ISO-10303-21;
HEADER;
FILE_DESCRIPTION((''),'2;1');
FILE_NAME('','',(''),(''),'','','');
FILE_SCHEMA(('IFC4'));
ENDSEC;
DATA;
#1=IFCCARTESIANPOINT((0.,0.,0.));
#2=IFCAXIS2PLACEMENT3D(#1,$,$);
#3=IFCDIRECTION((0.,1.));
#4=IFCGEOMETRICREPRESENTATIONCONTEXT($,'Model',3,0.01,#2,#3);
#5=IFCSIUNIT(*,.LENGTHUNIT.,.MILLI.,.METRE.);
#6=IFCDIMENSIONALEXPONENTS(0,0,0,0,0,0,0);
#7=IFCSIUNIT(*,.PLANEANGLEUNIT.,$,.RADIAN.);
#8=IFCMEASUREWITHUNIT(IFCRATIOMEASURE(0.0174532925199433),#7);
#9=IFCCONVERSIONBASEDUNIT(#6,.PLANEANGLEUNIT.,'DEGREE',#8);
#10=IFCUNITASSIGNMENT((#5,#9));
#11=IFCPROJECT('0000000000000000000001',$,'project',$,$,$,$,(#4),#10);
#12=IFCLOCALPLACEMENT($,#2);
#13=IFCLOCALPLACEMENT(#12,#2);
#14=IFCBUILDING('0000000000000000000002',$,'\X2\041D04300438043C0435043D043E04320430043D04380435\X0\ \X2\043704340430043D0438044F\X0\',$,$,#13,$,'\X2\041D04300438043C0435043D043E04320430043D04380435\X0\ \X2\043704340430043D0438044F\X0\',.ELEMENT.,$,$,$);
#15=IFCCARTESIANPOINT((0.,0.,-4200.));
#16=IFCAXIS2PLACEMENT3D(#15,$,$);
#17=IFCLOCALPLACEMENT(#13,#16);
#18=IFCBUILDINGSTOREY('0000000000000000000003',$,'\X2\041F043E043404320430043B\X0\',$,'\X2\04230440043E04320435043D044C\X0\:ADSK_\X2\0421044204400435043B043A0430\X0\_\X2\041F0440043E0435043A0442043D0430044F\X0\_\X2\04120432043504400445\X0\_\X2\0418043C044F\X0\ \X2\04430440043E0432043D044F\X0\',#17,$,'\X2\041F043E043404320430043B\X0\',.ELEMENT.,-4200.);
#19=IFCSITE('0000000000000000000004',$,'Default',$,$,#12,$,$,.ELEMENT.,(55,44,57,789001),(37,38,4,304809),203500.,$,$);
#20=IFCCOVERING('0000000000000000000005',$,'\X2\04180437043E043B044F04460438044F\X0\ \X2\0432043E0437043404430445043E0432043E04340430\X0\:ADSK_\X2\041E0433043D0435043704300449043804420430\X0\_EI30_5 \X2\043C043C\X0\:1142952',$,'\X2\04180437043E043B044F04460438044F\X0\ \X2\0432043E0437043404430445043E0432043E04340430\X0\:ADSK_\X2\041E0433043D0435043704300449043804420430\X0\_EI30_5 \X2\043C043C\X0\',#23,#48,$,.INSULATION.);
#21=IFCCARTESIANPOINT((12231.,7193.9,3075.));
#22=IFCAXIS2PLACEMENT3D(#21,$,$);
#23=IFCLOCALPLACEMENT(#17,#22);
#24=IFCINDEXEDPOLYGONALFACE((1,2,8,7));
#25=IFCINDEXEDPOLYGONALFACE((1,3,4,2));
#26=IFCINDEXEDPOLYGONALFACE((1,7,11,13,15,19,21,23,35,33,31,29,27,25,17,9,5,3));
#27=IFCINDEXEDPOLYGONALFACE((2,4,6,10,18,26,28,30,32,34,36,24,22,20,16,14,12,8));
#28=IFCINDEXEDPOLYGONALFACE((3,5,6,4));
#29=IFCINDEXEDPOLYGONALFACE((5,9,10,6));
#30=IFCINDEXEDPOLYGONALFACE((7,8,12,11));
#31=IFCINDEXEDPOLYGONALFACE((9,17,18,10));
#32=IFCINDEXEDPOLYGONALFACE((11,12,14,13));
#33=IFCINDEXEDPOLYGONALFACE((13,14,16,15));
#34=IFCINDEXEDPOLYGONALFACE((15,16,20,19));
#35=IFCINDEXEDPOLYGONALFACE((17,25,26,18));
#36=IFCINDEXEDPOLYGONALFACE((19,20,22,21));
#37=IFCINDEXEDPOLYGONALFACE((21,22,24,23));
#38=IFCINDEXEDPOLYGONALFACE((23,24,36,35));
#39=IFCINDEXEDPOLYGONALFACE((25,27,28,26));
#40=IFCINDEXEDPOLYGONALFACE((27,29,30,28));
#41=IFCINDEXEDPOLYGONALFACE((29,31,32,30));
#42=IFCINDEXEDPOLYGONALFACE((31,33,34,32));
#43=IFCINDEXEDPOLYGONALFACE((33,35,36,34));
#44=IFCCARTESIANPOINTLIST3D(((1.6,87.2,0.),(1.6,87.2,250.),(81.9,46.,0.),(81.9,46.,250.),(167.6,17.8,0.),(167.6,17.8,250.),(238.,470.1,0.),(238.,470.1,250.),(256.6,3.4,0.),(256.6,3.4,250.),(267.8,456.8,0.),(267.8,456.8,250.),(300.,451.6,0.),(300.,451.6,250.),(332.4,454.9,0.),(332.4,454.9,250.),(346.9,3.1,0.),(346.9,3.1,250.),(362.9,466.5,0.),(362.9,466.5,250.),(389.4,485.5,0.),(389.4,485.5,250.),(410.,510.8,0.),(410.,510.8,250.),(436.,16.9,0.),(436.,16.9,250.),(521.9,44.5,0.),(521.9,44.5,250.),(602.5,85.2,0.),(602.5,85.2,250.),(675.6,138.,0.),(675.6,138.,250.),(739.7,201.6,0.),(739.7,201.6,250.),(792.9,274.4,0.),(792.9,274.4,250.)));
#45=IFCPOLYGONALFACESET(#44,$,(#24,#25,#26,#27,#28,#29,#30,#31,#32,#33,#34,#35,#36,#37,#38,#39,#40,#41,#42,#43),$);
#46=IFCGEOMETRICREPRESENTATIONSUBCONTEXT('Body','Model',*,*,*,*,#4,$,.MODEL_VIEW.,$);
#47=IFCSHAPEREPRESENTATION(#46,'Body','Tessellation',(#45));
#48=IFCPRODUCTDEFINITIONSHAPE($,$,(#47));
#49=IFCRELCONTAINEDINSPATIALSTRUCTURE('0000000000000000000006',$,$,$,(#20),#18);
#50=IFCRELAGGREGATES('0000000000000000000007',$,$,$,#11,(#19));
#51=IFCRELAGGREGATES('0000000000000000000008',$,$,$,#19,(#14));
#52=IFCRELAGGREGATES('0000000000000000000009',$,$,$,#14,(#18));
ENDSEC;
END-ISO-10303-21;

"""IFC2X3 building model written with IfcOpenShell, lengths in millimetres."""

from ifc_helpers import new_model, entity, si_unit, converted_unit, direction, frame, frame_2d, origin, place, context, subcontext, project, spatial, polyline, circle_curve, parameter, trimmed, segment, composite_curve, outline, extrude, element, save


model = new_model("IFC2X3")

# Units and contexts
model_context = context("Model", 3, precision=0.01, world=origin(), true_north=direction((0.0, 1.0)))
body_context = subcontext(model_context, "Body", "Model", "MODEL_VIEW")
ifc_project = project(units=[si_unit("LENGTHUNIT", "METRE", prefix="MILLI"), converted_unit("PLANEANGLEUNIT", "DEGREE", entity("IfcRatioMeasure", 0.0174532925199433), si_unit("PLANEANGLEUNIT", "RADIAN"), dimensions=[0, 0, 0, 0, 0, 0, 0])], contexts=[model_context])

# Site, building, storey
site_placement = place(None, frame((0.0, 0.0, 0.0)))
site = spatial("IfcSite", under=ifc_project, at=site_placement, Name="Default", CompositionType="ELEMENT", RefLatitude=(55, 44, 57, 789001), RefLongitude=(37, 38, 4, 304809), RefElevation=203500.0)
building_placement = place(site_placement, origin())
building = spatial("IfcBuilding", under=site, at=building_placement, Name="Наименование здания", LongName="Наименование здания", CompositionType="ELEMENT")
storey_placement = place(building_placement, frame((0.0, 0.0, -4200.0)))
storey = spatial("IfcBuildingStorey", under=building, at=storey_placement, Name="Подвал", ObjectType="Уровень:ADSK_Стрелка_Проектная_Вверх_Имя уровня", LongName="Подвал", CompositionType="ELEMENT", Elevation=-4200.0)

# Covering
covering_1_placement = place(storey_placement, frame((12231.0, 7193.9, 3075.0)))
element("IfcCovering", 1, at=covering_1_placement, inside=storey, Name="Изоляция воздуховода:ADSK_Огнезащита_EI30_5 мм:1142952", ObjectType="Изоляция воздуховода:ADSK_Огнезащита_EI30_5 мм", PredefinedType="INSULATION", context=body_context, shape_type="SweptSolid", body=[
    extrude(outline(composite_curve([segment(polyline([(-175.0, 50.0), (-175.0, -400.0)]), True, "CONTINUOUS"), segment(trimmed(circle_curve(frame_2d((-175.0, 175.0), x_axis=(1.0, 0.0)), 575.0), [parameter(270.0)], [parameter(0.0)], True, "PARAMETER"), True, "CONTINUOUS"), segment(polyline([(400.0, 175.0), (-50.0, 175.0)]), True, "CONTINUOUS"), segment(trimmed(circle_curve(frame_2d((-175.0, 175.0), x_axis=(1.0, 0.0)), 125.0), [parameter(270.0)], [parameter(360.0)], True, "PARAMETER"), False, "CONTINUOUS")], self_intersect=False)), frame((360.6, 335.7, 0.0), z_axis=(0.0, 0.0, -1.0), x_axis=(-0.525347, -0.850888, 0.0)), (0.0, 0.0, -1.0), 250.0),
])

save(model, "model.ifc")
